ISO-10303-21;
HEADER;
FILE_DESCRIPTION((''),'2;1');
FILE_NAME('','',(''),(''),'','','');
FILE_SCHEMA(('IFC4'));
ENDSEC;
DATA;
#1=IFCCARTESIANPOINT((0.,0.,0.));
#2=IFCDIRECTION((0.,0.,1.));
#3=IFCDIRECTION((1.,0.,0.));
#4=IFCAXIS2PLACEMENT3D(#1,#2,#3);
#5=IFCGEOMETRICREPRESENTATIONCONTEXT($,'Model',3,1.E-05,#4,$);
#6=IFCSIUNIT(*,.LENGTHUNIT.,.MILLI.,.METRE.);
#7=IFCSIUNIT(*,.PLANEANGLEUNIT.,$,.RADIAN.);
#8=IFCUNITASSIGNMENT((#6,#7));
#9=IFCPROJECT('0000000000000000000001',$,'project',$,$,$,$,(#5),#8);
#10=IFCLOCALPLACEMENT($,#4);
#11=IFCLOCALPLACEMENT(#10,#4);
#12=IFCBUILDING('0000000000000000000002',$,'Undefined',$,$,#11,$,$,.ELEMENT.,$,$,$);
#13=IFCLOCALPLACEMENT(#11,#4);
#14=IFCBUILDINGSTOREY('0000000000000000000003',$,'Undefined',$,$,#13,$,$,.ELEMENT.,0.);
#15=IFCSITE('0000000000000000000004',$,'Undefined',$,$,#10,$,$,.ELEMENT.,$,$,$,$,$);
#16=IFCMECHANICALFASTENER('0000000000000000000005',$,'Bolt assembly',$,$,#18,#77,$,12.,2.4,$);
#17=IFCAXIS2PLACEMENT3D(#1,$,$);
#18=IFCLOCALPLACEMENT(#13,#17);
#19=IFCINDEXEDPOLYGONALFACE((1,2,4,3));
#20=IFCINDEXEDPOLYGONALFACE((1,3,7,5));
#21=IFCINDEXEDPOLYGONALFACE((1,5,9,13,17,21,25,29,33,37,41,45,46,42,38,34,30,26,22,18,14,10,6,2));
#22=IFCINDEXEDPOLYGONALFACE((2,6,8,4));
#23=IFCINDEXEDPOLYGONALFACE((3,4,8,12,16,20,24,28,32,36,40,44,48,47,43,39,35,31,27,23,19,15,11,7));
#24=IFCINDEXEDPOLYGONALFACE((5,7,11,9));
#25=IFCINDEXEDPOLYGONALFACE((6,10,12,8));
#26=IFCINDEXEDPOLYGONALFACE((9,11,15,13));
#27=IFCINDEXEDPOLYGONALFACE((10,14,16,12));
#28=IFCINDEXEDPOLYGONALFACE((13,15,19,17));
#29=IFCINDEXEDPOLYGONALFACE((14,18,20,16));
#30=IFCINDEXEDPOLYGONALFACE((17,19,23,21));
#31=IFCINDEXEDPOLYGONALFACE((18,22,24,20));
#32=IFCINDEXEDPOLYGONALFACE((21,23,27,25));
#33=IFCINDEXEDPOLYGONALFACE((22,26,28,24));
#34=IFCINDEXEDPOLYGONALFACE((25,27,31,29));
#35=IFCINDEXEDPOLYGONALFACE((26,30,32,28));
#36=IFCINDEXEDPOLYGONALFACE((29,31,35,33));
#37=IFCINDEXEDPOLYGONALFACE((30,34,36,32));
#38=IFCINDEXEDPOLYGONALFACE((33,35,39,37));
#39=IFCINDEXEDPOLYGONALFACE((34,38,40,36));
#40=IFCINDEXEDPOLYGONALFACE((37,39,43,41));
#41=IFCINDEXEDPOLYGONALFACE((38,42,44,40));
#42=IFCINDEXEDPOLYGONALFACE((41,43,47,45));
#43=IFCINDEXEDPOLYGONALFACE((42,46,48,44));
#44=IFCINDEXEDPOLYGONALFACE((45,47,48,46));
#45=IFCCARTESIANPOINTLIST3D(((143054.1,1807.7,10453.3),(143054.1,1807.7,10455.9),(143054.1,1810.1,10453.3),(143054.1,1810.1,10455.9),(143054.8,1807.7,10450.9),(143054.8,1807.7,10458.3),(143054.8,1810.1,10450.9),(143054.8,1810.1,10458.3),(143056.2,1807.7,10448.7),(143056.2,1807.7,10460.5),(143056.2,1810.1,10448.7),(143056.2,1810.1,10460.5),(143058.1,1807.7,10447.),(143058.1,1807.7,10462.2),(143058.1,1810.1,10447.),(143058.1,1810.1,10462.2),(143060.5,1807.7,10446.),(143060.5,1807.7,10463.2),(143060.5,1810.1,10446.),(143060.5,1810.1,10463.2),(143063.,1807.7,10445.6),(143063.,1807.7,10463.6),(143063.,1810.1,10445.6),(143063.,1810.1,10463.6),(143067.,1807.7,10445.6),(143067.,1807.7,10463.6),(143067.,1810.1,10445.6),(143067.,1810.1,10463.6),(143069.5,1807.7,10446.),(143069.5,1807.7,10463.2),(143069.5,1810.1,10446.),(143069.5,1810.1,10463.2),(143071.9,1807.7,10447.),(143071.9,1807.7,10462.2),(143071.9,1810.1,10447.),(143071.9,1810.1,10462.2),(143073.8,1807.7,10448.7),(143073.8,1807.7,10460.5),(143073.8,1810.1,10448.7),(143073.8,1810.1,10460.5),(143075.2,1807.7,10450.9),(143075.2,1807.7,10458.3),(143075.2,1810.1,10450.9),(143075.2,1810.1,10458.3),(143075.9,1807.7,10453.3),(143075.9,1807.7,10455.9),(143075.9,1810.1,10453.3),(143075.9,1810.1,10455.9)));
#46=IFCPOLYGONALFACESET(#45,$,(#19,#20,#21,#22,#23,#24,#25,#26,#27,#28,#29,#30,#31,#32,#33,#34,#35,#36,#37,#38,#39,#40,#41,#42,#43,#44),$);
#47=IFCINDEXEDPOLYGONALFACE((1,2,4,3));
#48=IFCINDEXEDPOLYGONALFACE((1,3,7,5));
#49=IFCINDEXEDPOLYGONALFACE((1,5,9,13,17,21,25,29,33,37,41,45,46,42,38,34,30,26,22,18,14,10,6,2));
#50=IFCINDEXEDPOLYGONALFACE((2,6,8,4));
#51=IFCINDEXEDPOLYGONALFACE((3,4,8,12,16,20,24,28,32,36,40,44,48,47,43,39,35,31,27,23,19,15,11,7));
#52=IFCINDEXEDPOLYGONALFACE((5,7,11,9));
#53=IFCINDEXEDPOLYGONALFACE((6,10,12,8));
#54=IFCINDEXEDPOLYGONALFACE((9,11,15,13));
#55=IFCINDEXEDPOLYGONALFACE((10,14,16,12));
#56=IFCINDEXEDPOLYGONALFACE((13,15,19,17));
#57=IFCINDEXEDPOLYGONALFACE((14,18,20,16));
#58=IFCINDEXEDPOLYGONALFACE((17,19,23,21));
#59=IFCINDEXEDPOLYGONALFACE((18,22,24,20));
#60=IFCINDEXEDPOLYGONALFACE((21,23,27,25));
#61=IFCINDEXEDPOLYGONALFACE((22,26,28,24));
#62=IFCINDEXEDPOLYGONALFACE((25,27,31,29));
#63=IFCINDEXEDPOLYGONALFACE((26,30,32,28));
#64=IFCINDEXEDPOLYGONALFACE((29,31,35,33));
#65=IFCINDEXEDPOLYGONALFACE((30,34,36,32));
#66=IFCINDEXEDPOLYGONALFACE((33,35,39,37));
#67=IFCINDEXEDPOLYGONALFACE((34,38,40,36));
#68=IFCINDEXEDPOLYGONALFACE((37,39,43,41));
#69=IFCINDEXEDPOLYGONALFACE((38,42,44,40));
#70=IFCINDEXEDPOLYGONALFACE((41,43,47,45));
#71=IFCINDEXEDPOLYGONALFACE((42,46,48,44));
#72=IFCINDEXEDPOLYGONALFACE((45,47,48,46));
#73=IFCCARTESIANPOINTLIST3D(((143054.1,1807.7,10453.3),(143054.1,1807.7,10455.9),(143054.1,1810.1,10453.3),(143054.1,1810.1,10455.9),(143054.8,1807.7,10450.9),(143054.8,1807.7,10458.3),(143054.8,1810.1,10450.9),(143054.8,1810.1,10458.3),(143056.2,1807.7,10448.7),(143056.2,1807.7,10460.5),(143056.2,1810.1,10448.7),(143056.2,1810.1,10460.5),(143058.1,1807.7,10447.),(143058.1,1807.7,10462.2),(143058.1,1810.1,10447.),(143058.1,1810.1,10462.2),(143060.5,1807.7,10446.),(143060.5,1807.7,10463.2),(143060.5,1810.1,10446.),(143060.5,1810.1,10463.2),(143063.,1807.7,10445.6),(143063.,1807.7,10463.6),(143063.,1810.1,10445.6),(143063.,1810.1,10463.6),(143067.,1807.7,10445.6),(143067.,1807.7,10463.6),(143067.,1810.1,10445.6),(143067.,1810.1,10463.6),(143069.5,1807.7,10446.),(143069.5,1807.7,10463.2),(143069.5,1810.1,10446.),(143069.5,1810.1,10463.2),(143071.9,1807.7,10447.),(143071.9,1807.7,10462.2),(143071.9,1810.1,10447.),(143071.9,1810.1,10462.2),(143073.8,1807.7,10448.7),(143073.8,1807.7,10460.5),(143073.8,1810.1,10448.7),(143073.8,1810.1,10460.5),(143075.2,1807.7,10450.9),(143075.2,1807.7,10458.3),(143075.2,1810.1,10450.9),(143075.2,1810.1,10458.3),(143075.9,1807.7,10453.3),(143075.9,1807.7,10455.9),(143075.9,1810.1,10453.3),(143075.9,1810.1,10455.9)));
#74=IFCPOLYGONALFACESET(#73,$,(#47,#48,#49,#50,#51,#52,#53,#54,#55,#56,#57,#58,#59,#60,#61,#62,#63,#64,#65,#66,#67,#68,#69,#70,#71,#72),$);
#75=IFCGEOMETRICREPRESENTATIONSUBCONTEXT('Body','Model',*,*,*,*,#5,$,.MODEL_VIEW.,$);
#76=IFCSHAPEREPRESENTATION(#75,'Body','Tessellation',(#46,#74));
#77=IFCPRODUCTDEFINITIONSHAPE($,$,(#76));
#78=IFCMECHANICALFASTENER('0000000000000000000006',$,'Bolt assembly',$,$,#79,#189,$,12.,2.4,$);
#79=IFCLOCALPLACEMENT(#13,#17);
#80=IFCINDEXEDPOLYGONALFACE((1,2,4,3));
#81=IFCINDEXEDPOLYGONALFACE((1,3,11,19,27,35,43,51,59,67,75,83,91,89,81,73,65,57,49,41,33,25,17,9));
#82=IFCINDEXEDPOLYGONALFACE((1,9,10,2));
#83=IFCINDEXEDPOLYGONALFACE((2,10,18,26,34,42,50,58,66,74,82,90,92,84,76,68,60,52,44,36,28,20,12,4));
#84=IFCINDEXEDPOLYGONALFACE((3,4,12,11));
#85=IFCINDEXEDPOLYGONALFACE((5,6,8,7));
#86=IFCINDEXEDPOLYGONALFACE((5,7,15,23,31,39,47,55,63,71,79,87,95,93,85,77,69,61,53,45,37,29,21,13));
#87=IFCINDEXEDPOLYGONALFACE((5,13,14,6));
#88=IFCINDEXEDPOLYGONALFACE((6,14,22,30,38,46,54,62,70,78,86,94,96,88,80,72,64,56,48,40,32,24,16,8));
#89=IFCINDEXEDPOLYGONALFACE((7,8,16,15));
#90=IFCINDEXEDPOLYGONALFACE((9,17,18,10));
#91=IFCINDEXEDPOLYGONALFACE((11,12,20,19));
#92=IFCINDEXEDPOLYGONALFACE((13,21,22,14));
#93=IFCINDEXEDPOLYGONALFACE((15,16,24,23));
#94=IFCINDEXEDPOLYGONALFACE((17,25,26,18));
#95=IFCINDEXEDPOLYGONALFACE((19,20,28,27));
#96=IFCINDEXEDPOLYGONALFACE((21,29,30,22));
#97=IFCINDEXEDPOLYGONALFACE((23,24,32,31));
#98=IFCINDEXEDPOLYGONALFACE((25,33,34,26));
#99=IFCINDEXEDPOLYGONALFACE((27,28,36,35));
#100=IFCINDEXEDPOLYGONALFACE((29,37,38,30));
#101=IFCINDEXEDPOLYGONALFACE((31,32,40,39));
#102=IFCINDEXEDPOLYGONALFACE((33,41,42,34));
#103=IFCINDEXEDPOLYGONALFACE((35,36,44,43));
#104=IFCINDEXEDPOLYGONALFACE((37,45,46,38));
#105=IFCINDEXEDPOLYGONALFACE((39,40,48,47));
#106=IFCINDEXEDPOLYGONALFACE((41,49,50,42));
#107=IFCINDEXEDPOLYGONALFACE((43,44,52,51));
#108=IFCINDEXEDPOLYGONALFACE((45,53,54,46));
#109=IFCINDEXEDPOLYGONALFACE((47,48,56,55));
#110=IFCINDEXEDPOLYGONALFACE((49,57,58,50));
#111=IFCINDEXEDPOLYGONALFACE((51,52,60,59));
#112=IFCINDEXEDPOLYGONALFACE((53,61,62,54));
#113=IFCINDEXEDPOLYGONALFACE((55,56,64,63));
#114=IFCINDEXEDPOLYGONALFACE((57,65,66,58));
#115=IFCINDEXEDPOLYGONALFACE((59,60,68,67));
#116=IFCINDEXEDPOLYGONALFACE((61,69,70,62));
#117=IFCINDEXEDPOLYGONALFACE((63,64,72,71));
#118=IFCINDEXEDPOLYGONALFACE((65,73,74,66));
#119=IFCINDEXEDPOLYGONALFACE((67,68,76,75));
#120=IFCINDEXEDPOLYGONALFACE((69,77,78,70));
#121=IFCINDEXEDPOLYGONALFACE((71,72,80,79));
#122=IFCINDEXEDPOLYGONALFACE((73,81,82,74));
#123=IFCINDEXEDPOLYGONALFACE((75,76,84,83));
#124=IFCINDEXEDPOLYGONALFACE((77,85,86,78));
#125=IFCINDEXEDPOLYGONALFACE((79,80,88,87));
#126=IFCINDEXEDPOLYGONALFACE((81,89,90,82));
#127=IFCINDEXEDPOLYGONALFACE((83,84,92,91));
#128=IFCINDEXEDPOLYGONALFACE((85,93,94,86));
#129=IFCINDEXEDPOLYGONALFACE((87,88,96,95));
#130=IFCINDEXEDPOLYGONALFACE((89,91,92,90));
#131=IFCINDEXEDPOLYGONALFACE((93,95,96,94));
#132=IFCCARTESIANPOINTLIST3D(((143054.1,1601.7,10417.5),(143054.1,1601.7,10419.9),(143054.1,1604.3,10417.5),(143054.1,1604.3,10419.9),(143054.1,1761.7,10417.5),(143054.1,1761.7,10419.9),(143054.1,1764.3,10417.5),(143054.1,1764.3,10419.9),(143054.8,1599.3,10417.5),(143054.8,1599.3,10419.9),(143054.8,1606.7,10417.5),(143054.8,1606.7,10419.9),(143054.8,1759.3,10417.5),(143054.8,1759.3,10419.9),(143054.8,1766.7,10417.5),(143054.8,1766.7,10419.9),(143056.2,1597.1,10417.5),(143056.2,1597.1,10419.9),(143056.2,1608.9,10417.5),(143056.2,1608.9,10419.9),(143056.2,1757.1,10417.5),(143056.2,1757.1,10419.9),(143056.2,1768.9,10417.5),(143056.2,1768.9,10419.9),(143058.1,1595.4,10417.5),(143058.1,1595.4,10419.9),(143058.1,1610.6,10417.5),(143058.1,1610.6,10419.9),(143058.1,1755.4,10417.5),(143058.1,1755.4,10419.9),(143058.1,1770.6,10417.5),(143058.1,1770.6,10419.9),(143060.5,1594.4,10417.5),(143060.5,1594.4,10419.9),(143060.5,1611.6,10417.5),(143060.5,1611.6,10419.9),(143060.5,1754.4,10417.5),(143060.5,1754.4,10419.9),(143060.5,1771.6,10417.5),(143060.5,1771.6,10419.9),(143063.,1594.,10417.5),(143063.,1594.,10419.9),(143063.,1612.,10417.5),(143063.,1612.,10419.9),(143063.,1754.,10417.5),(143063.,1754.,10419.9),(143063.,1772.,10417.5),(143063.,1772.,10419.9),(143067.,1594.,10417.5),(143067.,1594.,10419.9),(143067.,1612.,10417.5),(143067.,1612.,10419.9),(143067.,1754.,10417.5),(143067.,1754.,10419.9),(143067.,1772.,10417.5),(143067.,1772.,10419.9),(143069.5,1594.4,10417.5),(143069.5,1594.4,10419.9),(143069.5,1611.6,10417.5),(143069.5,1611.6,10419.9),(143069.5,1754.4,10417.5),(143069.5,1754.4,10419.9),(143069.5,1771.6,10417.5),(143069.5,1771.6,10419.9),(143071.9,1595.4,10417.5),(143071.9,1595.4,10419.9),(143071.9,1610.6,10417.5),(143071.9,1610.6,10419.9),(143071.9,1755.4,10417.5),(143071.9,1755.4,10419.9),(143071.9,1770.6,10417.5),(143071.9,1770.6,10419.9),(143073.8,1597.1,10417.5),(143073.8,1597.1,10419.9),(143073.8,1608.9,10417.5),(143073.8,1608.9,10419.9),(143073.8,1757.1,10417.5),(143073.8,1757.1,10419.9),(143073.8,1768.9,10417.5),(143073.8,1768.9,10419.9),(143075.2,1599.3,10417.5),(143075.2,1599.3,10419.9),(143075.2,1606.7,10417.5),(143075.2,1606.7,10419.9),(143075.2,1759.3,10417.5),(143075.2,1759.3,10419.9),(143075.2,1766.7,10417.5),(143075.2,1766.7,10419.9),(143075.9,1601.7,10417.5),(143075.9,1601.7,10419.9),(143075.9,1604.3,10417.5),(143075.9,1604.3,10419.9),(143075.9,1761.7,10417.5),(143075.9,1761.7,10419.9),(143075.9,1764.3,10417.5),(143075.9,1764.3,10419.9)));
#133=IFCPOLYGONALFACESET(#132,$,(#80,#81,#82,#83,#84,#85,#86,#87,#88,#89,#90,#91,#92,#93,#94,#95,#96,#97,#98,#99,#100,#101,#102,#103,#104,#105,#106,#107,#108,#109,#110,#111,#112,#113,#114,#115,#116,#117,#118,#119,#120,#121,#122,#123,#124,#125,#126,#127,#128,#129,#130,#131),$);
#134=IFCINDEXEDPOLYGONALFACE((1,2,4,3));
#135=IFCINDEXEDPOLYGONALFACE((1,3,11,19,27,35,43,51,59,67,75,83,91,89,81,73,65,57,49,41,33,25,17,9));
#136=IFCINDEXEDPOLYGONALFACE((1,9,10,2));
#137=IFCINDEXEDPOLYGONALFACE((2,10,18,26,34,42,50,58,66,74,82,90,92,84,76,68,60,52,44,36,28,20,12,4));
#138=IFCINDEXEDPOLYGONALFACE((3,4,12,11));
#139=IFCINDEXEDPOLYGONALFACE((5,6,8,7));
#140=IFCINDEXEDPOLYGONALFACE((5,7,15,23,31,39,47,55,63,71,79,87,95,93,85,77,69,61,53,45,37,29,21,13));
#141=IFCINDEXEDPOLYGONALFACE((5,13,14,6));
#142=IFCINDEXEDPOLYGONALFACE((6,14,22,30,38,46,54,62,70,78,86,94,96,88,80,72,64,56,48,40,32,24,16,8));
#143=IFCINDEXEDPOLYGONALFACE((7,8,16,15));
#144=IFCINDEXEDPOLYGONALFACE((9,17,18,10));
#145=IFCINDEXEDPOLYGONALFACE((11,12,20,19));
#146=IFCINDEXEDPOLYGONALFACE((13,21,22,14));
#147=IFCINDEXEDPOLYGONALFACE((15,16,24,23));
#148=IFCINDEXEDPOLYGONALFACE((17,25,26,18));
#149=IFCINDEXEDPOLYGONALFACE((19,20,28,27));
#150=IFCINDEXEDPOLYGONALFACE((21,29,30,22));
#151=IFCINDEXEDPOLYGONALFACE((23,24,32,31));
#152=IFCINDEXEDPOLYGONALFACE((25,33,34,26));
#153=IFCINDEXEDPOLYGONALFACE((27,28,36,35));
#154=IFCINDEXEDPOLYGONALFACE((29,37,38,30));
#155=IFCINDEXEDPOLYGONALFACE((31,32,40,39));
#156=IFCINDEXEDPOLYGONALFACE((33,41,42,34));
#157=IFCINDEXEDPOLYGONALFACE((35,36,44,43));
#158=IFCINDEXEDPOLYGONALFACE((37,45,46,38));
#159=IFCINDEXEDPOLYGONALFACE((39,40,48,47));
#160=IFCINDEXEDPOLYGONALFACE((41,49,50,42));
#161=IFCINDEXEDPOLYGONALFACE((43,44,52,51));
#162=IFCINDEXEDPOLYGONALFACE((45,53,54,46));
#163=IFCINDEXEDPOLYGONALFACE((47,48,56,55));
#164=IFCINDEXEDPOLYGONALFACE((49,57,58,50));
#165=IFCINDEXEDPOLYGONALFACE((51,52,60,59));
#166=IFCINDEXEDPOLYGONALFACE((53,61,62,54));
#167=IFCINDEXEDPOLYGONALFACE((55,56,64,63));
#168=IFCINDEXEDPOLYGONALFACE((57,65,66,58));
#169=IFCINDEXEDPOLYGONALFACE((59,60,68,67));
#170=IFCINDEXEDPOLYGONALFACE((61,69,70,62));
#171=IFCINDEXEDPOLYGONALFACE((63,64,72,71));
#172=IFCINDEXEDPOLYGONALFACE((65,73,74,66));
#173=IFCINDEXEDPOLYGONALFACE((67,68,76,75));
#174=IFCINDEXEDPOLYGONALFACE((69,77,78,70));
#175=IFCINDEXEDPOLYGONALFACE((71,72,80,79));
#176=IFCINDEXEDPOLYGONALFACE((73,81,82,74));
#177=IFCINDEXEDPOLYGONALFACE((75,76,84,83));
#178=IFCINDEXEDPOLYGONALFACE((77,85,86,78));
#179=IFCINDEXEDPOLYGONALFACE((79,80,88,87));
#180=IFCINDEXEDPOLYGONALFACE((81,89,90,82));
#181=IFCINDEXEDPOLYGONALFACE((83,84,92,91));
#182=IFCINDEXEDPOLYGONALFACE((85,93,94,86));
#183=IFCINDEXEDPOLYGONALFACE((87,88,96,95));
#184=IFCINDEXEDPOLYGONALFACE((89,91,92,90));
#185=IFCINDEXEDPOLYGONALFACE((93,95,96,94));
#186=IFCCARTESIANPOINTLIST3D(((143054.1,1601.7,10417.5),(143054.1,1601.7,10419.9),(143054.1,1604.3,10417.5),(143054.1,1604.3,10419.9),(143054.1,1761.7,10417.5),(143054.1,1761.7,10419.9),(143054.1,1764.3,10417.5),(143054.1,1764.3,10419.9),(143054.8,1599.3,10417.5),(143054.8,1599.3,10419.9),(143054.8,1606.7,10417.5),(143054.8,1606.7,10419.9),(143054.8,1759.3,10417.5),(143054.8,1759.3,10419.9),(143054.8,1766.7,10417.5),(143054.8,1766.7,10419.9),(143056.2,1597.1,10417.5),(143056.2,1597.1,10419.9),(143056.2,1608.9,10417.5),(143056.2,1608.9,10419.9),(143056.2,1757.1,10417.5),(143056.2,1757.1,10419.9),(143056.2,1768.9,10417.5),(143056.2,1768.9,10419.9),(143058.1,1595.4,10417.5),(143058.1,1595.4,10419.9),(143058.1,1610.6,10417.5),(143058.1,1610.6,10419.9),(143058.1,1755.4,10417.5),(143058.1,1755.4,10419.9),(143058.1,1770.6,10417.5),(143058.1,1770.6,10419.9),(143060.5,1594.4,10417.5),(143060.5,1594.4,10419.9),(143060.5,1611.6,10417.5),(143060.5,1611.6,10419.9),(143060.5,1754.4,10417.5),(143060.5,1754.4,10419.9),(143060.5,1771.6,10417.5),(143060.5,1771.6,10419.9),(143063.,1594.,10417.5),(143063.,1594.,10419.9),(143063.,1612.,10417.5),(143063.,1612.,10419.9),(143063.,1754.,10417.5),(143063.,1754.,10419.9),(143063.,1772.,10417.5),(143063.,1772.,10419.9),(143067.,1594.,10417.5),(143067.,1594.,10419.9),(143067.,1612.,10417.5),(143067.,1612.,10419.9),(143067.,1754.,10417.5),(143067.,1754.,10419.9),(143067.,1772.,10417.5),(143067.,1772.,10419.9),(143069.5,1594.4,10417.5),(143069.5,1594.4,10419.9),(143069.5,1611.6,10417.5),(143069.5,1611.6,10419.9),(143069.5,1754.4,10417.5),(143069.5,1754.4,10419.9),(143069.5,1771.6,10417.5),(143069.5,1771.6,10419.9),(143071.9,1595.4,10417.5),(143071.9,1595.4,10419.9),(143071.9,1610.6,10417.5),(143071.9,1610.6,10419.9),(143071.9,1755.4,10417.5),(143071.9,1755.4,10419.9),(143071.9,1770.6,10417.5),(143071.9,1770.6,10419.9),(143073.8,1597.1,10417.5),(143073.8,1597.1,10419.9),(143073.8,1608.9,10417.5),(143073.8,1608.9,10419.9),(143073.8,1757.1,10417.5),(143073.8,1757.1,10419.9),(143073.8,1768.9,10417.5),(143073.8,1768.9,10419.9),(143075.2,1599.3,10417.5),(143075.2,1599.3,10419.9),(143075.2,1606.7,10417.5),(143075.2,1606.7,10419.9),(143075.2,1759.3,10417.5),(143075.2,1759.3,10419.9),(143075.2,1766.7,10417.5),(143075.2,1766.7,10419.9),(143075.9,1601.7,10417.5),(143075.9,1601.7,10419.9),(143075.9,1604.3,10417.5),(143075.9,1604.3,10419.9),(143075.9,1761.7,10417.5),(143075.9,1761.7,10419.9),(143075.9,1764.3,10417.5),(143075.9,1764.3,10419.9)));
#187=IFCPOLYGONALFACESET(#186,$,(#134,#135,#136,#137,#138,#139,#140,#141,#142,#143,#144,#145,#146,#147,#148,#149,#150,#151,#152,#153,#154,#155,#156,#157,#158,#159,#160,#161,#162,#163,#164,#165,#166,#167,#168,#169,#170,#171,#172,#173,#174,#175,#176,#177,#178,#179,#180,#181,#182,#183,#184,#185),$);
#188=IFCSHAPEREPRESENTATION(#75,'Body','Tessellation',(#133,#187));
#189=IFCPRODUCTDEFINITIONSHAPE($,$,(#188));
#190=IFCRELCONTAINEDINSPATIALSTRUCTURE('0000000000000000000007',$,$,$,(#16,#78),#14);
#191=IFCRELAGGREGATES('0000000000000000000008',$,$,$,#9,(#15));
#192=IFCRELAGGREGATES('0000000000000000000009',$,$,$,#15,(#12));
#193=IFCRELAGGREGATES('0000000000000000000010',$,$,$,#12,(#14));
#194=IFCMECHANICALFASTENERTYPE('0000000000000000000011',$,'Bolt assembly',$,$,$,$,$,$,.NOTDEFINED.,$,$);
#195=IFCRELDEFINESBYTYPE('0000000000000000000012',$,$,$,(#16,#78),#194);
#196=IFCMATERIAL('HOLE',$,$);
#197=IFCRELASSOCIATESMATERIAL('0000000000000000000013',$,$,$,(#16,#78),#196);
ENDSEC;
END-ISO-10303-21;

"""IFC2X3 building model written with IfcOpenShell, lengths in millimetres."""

from ifc_helpers import new_model, entity, si_unit, frame, origin_with_axes, place, context, subcontext, project, spatial, source, transform, mapped, material, type_object, element, save


model = new_model("IFC2X3")

# Units and contexts
model_context = context("Model", 3, precision=1e-05, world=origin_with_axes())
body_context = subcontext(model_context, "Body", "Model", "MODEL_VIEW")
ifc_project = project(units=[si_unit("LENGTHUNIT", "METRE", prefix="MILLI"), si_unit("PLANEANGLEUNIT", "RADIAN")], contexts=[model_context])

# Site, building, storey
site_placement = place(None, origin_with_axes())
site = spatial("IfcSite", under=ifc_project, at=site_placement, Name="Undefined", CompositionType="ELEMENT")
building_placement = place(site_placement, origin_with_axes())
building = spatial("IfcBuilding", under=site, at=building_placement, Name="Undefined", CompositionType="ELEMENT")
storey_placement = place(building_placement, origin_with_axes())
storey = spatial("IfcBuildingStorey", under=building, at=storey_placement, Name="Undefined", CompositionType="ELEMENT", Elevation=0.0)

# Mechanical fasteners
mechanical_fastener_type = type_object("IfcMechanicalFastenerType", Name="Bolt assembly")
ifc_material_1 = material(Name="HOLE")
shared_circle_1 = entity("IfcCircle", entity("IfcAxis2Placement2D", entity("IfcCartesianPoint", [2.0, 0.0]), entity("IfcDirection", [0.0, 1.0])), 9.0)
shared_circle_2 = entity("IfcCircle", entity("IfcAxis2Placement2D", entity("IfcCartesianPoint", [-2.0, 0.0]), entity("IfcDirection", [0.0, -1.0])), 9.0)
shared_composite_curve = entity("IfcCompositeCurve", [entity("IfcCompositeCurveSegment", "CONTINUOUS", True, entity("IfcPolyline", [entity("IfcCartesianPoint", [-2.0, 9.0]), entity("IfcCartesianPoint", [2.0, 9.0])])), entity("IfcCompositeCurveSegment", "CONTINUOUS", True, entity("IfcTrimmedCurve", shared_circle_1, [entity("IfcParameterValue", 0.0)], [entity("IfcParameterValue", 3.141593)], False, "PARAMETER")), entity("IfcCompositeCurveSegment", "CONTINUOUS", True, entity("IfcPolyline", [entity("IfcCartesianPoint", [2.0, -9.0]), entity("IfcCartesianPoint", [-2.0, -9.0])])), entity("IfcCompositeCurveSegment", "DISCONTINUOUS", True, entity("IfcTrimmedCurve", shared_circle_2, [entity("IfcParameterValue", 0.0)], [entity("IfcParameterValue", 3.141593)], False, "PARAMETER"))], False)
shared_shape_1 = source(origin_with_axes(), body_context, "Body", "SweptSolid", [
    entity("IfcExtrudedAreaSolid", entity("IfcArbitraryClosedProfileDef", "AREA", None, shared_composite_curve), entity("IfcAxis2Placement3D", entity("IfcCartesianPoint", [0.0, 0.1, 0.0]), entity("IfcDirection", [0.0, 1.0, 0.0]), entity("IfcDirection", [1.0, 0.0, 0.0])), entity("IfcDirection", [0.0, 0.0, 1.0]), 2.4),
    entity("IfcExtrudedAreaSolid", entity("IfcArbitraryClosedProfileDef", "AREA", None, shared_composite_curve), entity("IfcAxis2Placement3D", entity("IfcCartesianPoint", [0.0, 0.1, 0.0]), entity("IfcDirection", [0.0, 1.0, 0.0]), entity("IfcDirection", [1.0, 0.0, 0.0])), entity("IfcDirection", [0.0, 0.0, 1.0]), 2.4),
])
mechanical_fastener_1_placement = place(storey_placement, frame((143065.0, 1807.6, 10454.6), z_axis=(0.0, 0.0, -1.0), x_axis=(-1.0, 0.0, 0.0)))
element("IfcMechanicalFastener", 1, at=mechanical_fastener_1_placement, inside=storey, type_object=mechanical_fastener_type, material=ifc_material_1, Name="Bolt assembly", NominalDiameter=12.0, NominalLength=2.4, context=body_context, shape_type="MappedRepresentation", body=[
    mapped(shared_shape_1, transform((0.0, 0.0, 0.0))),
])
shared_shape_2 = source(origin_with_axes(), body_context, "Body", "SweptSolid", [
    entity("IfcExtrudedAreaSolid", entity("IfcArbitraryClosedProfileDef", "AREA", None, shared_composite_curve), entity("IfcAxis2Placement3D", entity("IfcCartesianPoint", [0.0, -2.3, 0.0]), entity("IfcDirection", [0.0, 1.0, 0.0]), entity("IfcDirection", [1.0, 0.0, 0.0])), entity("IfcDirection", [0.0, 0.0, 1.0]), 2.4),
    entity("IfcExtrudedAreaSolid", entity("IfcArbitraryClosedProfileDef", "AREA", None, shared_composite_curve), entity("IfcAxis2Placement3D", entity("IfcCartesianPoint", [0.0, -2.3, 0.0]), entity("IfcDirection", [0.0, 1.0, 0.0]), entity("IfcDirection", [1.0, 0.0, 0.0])), entity("IfcDirection", [0.0, 0.0, 1.0]), 2.4),
])
mechanical_fastener_2_placement = place(storey_placement, frame((143065.0, 1683.0, 10417.6), z_axis=(0.0, -1.0, 0.0), x_axis=(-1.0, 0.0, 0.0)))
element("IfcMechanicalFastener", 2, at=mechanical_fastener_2_placement, inside=storey, type_object=mechanical_fastener_type, material=ifc_material_1, Name="Bolt assembly", NominalDiameter=12.0, NominalLength=2.4, context=body_context, shape_type="MappedRepresentation", body=[
    mapped(shared_shape_2, transform((0.0, 0.0, -80.0))),
    mapped(shared_shape_2, transform((0.0, 0.0, 80.0))),
])

save(model, "model.ifc")
